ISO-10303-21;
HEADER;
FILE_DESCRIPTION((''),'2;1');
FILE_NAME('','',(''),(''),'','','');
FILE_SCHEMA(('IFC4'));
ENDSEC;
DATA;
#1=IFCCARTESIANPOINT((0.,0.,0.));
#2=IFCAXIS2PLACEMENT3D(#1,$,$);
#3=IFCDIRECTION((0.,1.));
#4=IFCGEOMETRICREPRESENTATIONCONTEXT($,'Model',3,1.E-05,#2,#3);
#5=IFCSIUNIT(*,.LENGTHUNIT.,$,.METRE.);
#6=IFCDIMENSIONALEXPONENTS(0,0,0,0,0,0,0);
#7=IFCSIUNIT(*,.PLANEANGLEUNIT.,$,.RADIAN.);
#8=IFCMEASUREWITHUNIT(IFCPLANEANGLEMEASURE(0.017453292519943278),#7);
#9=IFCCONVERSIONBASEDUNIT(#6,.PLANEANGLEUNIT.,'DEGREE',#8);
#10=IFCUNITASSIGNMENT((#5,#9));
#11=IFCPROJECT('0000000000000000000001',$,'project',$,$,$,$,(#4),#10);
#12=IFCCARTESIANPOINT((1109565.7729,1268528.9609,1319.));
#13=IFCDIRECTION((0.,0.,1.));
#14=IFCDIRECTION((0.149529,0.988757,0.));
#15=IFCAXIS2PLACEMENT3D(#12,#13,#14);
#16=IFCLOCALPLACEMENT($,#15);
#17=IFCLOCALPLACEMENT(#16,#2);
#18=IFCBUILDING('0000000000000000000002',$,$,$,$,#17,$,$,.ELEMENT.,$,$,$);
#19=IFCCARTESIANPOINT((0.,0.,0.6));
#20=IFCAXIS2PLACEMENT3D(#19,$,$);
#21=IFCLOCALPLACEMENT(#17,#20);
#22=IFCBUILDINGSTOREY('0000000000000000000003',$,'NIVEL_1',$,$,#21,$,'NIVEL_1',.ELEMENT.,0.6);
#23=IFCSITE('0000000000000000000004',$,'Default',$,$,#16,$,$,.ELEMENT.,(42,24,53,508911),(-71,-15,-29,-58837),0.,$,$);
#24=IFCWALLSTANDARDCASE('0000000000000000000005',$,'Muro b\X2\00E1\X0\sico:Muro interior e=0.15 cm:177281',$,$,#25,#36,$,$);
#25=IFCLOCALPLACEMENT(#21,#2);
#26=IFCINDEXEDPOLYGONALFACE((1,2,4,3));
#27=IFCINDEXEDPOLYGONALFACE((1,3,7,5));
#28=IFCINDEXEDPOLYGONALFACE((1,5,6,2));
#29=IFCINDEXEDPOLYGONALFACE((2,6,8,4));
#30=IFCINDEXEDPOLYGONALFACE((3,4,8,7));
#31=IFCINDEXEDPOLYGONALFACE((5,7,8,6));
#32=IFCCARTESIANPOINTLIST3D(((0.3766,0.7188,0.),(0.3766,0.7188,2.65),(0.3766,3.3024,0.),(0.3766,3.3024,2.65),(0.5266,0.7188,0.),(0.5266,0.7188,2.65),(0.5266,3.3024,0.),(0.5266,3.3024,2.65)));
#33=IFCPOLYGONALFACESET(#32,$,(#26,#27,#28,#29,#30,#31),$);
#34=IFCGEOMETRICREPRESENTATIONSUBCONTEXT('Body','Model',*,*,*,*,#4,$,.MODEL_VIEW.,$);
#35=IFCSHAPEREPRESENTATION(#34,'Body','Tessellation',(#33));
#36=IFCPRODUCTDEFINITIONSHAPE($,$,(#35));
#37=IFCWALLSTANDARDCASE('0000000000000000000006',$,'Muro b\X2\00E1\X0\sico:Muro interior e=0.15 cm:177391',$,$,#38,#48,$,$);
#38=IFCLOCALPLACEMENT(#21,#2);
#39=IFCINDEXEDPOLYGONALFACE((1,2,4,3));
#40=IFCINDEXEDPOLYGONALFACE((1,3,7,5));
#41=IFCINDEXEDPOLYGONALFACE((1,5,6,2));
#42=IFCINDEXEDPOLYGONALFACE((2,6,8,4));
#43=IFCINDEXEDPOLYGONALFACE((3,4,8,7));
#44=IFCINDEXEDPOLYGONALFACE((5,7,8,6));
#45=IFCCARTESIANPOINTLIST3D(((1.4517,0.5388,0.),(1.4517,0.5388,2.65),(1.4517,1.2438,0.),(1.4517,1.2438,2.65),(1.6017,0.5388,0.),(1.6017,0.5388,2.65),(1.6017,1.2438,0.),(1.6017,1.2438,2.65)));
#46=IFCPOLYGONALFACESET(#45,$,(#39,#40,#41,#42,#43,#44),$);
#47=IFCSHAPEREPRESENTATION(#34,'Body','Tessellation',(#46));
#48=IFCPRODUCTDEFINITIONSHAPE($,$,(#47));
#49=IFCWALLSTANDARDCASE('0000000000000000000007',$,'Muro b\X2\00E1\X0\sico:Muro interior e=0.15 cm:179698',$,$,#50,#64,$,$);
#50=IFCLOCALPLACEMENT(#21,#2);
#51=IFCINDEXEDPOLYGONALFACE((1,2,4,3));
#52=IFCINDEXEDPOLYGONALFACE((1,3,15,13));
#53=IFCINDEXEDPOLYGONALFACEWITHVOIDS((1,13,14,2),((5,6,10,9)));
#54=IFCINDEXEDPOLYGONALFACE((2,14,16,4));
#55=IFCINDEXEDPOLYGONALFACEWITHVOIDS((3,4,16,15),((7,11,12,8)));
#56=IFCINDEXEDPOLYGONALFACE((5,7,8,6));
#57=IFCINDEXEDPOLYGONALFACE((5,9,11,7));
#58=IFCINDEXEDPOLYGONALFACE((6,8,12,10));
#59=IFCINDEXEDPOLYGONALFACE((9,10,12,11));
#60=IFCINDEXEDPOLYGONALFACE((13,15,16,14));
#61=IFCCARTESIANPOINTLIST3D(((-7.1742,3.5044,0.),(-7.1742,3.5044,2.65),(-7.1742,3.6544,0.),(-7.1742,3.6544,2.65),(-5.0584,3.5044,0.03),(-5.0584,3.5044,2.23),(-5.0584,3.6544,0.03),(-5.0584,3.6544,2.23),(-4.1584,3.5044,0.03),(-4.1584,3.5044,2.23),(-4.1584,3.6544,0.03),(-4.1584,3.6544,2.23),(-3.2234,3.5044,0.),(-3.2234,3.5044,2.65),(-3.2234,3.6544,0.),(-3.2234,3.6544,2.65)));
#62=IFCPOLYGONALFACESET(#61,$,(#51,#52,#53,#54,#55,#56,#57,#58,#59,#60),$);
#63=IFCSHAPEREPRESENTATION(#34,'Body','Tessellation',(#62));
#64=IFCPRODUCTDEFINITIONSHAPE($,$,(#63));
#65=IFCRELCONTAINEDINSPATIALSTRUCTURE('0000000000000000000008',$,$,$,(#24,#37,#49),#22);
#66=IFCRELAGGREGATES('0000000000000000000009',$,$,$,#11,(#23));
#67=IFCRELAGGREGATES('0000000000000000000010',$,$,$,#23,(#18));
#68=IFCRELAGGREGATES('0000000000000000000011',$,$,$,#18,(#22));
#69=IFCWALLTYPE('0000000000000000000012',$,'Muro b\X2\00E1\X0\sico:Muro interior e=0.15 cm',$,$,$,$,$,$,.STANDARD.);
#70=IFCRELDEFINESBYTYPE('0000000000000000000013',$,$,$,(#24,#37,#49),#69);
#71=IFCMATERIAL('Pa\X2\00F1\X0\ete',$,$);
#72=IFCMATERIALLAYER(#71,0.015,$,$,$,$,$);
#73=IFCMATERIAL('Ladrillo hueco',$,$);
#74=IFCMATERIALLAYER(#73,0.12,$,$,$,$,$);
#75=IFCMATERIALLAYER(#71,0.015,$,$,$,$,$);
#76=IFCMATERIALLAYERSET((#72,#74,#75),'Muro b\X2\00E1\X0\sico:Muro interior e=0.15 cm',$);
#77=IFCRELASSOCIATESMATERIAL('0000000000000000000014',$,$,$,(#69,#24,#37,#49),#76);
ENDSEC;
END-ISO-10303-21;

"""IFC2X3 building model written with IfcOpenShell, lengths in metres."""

from ifc_helpers import new_model, entity, si_unit, converted_unit, direction, frame, frame_2d, origin, place, context, subcontext, project, spatial, rectangle, extrude, material, layer, layer_set, layer_usage, type_object, element, save


model = new_model("IFC2X3")

# Units and contexts
model_context = context("Model", 3, precision=1e-05, world=origin(), true_north=direction((0.0, 1.0)))
body_context = subcontext(model_context, "Body", "Model", "MODEL_VIEW")
ifc_project = project(units=[si_unit("LENGTHUNIT", "METRE"), converted_unit("PLANEANGLEUNIT", "DEGREE", entity("IfcPlaneAngleMeasure", 0.017453292519943278), si_unit("PLANEANGLEUNIT", "RADIAN"), dimensions=[0, 0, 0, 0, 0, 0, 0])], contexts=[model_context])

# Site, building, storey
site_placement = place(None, frame((1109565.7729, 1268528.9609, 1319.0), z_axis=(0.0, 0.0, 1.0), x_axis=(0.149529, 0.988757, 0.0)))
site = spatial("IfcSite", under=ifc_project, at=site_placement, Name="Default", CompositionType="ELEMENT", RefLatitude=(42, 24, 53, 508911), RefLongitude=(-71, -15, -29, -58837), RefElevation=0.0)
building_placement = place(site_placement, origin())
building = spatial("IfcBuilding", under=site, at=building_placement, CompositionType="ELEMENT")
storey_placement = place(building_placement, frame((0.0, 0.0, 0.6)))
storey = spatial("IfcBuildingStorey", under=building, at=storey_placement, Name="NIVEL_1", LongName="NIVEL_1", CompositionType="ELEMENT", Elevation=0.6)

# Walls
ifc_material_1 = material(Name="Pañete")
ifc_layer_1 = layer(ifc_material_1, 0.015)
ifc_material_2 = material(Name="Ladrillo hueco")
ifc_layer_2 = layer(ifc_material_2, 0.12)
ifc_layer_3 = layer(ifc_material_1, 0.015)
ifc_layer_set_1 = layer_set([ifc_layer_1, ifc_layer_2, ifc_layer_3], Name="Muro básico:Muro interior e=0.15 cm")
ifc_layer_usage_1 = layer_usage(ifc_layer_set_1, "AXIS2", "NEGATIVE", 0.075)
wall_type_1 = type_object("IfcWallType", Name="Muro básico:Muro interior e=0.15 cm", PredefinedType="STANDARD", material=ifc_layer_set_1)
wall_1_placement = place(storey_placement, frame((0.4516, 0.7188, 0.0), z_axis=(0.0, 0.0, 1.0), x_axis=(0.0, 1.0, 0.0)))
element("IfcWallStandardCase", 1, at=wall_1_placement, inside=storey, type_object=wall_type_1, material=ifc_layer_usage_1, Name="Muro básico:Muro interior e=0.15 cm:177281", context=body_context, shape_type="SweptSolid", body=[
    extrude(rectangle(XDim=2.5836, YDim=0.15, at=frame_2d((1.2918, 0.0), x_axis=(-1.0, 0.0))), origin(), (0.0, 0.0, 1.0), 2.65),
])
ifc_layer_usage_2 = layer_usage(ifc_layer_set_1, "AXIS2", "POSITIVE", -0.075)
wall_2_placement = place(storey_placement, frame((1.5267, 1.2438, 0.0), z_axis=(0.0, 0.0, 1.0), x_axis=(0.0, -1.0, 0.0)))
element("IfcWallStandardCase", 2, at=wall_2_placement, inside=storey, type_object=wall_type_1, material=ifc_layer_usage_2, Name="Muro básico:Muro interior e=0.15 cm:177391", context=body_context, shape_type="SweptSolid", body=[
    extrude(rectangle(XDim=0.705, YDim=0.15, at=frame_2d((0.3525, 0.0), x_axis=(-1.0, 0.0))), origin(), (0.0, 0.0, 1.0), 2.65),
])

# Wall, opening
ifc_layer_usage_3 = layer_usage(ifc_layer_set_1, "AXIS2", "NEGATIVE", 0.075)
wall_3_placement = place(storey_placement, frame((-3.2234, 3.5794, 0.0), z_axis=(0.0, 0.0, 1.0), x_axis=(-1.0, 0.0, 0.0)))
wall_3 = element("IfcWallStandardCase", 3, at=wall_3_placement, inside=storey, type_object=wall_type_1, material=ifc_layer_usage_3, Name="Muro básico:Muro interior e=0.15 cm:179698", context=body_context, shape_type="SweptSolid", body=[
    extrude(rectangle(XDim=3.9509, YDim=0.15, at=frame_2d((1.9754, 0.0), x_axis=(-1.0, 0.0))), origin(), (0.0, 0.0, 1.0), 2.65),
])
opening_1_placement = place(wall_3_placement, frame((1.835, 0.075, 0.03)))
element("IfcOpeningElement", 4, at=opening_1_placement, cuts=wall_3, ObjectType="Opening", context=body_context, shape_type="SweptSolid", body=[
    extrude(rectangle(XDim=2.2, YDim=0.9, at=frame_2d((1.1, 0.45), x_axis=(1.0, 0.0))), frame((0.0, 0.0, 0.0), z_axis=(0.0, -1.0, 0.0), x_axis=(0.0, 0.0, 1.0)), (0.0, 0.0, 1.0), 0.15),
])

save(model, "model.ifc")
